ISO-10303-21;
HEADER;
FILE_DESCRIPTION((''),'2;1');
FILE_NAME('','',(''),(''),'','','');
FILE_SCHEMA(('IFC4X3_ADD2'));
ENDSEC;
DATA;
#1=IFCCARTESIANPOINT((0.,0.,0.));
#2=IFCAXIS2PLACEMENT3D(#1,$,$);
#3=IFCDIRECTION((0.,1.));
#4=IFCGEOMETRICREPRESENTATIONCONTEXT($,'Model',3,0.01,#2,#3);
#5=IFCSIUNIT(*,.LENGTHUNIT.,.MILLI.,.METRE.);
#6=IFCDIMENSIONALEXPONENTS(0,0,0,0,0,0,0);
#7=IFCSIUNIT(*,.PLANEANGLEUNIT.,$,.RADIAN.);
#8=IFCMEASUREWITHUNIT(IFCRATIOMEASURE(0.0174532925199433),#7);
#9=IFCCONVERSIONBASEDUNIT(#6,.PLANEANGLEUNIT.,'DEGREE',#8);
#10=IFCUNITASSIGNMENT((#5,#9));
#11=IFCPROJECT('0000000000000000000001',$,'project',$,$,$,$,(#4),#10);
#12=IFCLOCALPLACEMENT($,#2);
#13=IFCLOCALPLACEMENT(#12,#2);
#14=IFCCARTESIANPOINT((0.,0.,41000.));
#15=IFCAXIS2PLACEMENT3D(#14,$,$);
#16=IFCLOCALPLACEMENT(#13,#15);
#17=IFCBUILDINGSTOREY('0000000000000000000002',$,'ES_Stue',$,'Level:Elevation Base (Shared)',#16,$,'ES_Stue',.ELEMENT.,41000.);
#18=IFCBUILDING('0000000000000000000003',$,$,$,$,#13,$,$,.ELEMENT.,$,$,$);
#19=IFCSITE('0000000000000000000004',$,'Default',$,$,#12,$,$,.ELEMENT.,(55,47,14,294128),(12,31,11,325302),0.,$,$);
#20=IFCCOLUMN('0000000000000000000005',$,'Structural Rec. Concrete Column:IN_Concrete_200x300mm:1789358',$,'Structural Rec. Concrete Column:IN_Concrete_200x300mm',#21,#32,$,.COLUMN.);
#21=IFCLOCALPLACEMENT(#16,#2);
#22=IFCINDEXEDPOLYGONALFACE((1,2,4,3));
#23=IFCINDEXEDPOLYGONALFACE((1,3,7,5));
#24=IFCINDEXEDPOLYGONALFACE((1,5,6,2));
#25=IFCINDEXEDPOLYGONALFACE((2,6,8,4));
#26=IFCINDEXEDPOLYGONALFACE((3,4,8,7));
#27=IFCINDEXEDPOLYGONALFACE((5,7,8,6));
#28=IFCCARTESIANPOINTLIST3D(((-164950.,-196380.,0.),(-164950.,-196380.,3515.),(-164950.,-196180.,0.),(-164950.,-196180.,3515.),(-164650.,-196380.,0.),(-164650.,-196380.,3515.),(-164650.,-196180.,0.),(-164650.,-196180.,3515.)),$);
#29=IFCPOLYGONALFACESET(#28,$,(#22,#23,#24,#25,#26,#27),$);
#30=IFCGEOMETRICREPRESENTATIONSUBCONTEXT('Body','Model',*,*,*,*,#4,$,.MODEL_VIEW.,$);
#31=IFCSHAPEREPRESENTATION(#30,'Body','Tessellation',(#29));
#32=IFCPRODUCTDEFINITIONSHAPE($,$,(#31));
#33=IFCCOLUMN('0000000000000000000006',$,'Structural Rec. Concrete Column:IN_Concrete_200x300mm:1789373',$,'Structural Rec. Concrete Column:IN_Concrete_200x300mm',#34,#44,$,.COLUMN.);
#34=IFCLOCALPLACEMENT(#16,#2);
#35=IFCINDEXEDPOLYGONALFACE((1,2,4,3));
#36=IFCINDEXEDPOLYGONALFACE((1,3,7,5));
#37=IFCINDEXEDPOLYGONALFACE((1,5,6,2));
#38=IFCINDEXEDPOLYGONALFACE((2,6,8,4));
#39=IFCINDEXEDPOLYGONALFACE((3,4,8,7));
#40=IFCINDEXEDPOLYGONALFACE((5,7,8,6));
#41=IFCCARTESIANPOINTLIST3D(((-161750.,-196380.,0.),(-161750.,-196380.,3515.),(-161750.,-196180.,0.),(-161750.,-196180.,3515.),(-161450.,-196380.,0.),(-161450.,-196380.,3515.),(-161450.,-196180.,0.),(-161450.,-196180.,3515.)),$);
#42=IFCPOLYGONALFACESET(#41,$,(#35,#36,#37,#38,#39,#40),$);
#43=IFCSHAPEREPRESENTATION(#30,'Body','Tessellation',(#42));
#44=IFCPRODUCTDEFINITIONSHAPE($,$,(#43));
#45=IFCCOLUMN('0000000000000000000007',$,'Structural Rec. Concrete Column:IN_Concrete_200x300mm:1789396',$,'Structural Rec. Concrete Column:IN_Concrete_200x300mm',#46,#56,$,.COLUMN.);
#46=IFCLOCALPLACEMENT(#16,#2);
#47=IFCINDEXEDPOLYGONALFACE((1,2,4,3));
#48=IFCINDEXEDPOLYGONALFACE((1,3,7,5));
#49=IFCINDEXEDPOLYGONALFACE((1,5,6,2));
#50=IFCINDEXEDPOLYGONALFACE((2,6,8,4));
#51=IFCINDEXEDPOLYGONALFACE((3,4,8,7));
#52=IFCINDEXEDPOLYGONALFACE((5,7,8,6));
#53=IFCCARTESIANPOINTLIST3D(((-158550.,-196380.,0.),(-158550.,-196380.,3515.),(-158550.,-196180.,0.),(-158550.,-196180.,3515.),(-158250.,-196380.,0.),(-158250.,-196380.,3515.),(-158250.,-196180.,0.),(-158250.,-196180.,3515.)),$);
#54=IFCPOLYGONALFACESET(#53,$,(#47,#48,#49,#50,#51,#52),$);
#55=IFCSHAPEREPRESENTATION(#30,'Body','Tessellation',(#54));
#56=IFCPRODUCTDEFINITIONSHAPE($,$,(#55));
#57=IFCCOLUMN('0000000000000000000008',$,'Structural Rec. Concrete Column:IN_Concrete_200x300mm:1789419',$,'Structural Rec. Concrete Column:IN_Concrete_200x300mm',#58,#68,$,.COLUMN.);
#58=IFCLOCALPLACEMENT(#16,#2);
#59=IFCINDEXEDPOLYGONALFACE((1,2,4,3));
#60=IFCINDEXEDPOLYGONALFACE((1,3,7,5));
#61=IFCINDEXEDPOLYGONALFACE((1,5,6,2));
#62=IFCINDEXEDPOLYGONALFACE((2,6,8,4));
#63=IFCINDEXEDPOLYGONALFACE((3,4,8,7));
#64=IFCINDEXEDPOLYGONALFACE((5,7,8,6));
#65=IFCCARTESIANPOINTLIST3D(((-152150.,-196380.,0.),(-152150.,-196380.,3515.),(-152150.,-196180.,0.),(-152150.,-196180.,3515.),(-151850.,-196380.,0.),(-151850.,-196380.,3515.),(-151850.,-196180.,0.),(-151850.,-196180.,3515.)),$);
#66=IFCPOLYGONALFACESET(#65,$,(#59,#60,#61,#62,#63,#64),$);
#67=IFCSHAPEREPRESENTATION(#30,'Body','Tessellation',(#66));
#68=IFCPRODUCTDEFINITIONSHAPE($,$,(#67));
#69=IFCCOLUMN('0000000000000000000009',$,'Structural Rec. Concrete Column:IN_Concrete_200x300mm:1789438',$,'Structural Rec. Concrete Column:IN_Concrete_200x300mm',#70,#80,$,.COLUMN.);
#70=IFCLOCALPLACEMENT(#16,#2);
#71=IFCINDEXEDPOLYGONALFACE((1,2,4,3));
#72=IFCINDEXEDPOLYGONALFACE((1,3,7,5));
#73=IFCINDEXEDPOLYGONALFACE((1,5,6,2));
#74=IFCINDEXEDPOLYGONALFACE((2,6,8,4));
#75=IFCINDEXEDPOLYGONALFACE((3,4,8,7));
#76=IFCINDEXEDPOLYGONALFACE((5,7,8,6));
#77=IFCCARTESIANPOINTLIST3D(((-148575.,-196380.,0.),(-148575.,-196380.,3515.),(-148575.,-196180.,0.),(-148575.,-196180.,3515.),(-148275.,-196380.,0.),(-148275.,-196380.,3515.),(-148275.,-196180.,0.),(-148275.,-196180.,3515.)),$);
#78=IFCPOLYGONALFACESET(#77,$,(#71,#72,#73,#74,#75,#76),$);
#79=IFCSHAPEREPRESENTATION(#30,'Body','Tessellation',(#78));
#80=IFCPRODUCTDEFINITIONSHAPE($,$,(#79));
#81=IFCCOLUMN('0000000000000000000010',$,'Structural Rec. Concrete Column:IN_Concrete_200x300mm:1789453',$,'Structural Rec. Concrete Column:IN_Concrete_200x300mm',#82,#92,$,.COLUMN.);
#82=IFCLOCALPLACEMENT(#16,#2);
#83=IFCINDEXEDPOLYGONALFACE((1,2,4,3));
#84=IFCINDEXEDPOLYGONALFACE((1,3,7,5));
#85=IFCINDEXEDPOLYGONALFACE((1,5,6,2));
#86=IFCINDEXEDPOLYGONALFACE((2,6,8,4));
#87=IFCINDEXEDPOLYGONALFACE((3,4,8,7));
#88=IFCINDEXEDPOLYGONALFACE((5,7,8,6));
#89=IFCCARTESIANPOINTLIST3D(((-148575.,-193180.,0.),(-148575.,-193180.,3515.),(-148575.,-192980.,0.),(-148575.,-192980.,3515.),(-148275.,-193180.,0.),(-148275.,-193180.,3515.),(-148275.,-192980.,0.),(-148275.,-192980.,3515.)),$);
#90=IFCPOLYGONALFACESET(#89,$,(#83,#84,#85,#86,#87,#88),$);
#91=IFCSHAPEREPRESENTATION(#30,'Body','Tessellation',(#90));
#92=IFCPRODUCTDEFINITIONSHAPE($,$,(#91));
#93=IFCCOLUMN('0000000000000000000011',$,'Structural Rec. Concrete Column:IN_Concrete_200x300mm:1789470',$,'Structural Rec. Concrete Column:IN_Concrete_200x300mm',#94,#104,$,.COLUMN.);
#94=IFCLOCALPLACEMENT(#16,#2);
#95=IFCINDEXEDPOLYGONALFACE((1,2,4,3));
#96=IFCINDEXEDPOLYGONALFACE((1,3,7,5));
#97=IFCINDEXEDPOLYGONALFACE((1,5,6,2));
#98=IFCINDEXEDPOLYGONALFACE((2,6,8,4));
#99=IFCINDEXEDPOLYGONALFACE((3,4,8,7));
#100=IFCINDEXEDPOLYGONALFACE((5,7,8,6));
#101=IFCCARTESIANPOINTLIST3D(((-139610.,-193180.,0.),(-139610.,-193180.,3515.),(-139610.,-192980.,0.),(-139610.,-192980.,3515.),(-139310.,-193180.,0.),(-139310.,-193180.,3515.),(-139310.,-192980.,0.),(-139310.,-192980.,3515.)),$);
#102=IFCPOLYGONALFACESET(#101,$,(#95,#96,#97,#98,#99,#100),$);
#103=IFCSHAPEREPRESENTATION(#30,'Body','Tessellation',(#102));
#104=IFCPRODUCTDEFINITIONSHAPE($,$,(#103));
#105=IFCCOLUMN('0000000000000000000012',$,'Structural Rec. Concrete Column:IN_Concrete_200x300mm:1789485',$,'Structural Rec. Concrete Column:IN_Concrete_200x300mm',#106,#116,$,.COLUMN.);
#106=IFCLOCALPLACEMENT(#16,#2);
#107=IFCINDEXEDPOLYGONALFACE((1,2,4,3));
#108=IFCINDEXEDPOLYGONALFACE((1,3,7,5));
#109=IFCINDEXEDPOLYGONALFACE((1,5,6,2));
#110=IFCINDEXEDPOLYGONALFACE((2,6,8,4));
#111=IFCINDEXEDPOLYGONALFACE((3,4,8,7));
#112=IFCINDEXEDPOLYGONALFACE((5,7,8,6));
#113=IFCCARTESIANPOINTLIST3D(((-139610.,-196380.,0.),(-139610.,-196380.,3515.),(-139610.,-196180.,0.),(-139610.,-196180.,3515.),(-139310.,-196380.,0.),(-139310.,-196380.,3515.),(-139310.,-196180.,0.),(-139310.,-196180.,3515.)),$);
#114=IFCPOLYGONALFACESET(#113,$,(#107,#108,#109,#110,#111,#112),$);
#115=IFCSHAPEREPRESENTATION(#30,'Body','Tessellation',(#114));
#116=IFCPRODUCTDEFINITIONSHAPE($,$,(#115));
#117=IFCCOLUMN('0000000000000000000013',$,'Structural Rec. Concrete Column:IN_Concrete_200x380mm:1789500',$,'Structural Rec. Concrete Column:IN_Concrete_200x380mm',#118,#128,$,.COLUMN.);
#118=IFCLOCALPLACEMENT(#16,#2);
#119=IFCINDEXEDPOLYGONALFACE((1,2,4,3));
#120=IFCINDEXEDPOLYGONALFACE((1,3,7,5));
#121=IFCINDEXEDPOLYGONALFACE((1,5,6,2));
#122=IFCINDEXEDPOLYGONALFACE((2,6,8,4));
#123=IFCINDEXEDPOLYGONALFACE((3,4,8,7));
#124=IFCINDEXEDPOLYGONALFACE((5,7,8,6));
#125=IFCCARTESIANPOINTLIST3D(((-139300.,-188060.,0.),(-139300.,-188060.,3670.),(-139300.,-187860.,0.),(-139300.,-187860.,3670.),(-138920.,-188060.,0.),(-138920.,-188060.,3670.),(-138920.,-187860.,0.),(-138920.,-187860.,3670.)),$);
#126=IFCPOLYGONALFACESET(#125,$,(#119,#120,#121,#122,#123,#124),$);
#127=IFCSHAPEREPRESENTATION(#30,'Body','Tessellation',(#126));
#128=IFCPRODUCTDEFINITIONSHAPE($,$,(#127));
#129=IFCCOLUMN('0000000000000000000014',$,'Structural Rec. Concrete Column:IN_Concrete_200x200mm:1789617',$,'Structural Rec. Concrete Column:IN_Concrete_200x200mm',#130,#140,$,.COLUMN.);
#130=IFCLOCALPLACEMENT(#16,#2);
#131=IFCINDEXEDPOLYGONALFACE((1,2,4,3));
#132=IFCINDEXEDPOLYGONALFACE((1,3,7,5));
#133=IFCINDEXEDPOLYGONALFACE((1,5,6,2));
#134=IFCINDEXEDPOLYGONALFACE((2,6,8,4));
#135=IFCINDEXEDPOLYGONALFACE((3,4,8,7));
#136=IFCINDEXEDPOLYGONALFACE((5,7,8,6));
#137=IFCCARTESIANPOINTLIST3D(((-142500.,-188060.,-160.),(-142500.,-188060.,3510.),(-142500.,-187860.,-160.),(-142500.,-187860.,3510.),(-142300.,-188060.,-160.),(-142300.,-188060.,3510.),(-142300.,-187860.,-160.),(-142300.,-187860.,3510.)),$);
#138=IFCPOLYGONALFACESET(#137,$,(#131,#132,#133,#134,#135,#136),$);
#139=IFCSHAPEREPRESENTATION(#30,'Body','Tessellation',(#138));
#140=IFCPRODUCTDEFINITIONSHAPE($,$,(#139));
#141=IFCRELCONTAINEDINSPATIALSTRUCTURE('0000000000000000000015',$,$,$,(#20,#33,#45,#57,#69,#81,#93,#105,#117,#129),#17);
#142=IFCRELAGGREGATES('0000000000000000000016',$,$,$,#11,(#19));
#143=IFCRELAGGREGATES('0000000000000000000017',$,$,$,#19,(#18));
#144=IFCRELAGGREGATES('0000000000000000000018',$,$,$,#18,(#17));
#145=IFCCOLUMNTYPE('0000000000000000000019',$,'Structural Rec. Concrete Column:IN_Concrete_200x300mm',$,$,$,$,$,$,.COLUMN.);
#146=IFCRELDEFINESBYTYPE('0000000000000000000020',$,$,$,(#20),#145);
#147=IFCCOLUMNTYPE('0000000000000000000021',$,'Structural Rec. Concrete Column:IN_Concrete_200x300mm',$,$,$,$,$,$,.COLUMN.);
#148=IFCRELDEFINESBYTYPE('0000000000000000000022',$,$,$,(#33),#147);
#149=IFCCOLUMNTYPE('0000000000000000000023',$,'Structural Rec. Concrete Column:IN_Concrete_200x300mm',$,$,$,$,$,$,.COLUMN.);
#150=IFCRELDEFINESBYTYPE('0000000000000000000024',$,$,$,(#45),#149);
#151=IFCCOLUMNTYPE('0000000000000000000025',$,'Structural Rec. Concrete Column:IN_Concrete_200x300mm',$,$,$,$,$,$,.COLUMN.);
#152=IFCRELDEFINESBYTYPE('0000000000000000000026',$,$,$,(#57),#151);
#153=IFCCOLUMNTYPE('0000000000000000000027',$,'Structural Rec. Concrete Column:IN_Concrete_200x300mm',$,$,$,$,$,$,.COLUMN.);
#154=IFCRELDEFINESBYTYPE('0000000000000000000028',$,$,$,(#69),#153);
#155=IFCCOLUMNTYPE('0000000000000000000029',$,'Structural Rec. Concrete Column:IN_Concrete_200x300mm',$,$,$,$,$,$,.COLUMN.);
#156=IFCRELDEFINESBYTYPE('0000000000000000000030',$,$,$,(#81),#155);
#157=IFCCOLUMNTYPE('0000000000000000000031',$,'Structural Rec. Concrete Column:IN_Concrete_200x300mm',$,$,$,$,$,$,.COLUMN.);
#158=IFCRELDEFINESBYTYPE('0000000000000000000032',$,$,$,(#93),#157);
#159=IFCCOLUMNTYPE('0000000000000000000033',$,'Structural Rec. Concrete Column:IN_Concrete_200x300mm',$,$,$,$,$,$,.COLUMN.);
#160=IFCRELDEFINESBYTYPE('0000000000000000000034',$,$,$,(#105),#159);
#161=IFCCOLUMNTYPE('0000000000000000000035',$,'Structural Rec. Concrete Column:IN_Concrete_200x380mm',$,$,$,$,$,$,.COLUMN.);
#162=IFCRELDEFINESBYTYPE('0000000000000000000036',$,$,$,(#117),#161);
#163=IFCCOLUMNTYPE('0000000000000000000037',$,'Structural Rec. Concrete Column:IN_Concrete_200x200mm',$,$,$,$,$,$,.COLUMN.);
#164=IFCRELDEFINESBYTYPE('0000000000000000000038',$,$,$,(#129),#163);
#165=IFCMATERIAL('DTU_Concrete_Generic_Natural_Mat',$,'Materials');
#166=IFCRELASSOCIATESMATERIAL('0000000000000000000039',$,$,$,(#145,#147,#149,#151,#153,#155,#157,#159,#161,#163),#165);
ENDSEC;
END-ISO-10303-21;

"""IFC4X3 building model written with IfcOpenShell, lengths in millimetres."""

from ifc_helpers import new_model, entity, si_unit, converted_unit, direction, frame, origin, origin_2d_with_axis, place, context, subcontext, project, spatial, rectangle, extrude, source, transform, mapped, material, material_profile, profile_set, type_object, type_shapes, element, save


model = new_model("IFC4X3")

# Units and contexts
model_context = context("Model", 3, precision=0.01, world=origin(), true_north=direction((0.0, 1.0)))
body_context = subcontext(model_context, "Body", "Model", "MODEL_VIEW")
ifc_project = project(units=[si_unit("LENGTHUNIT", "METRE", prefix="MILLI"), converted_unit("PLANEANGLEUNIT", "DEGREE", entity("IfcRatioMeasure", 0.0174532925199433), si_unit("PLANEANGLEUNIT", "RADIAN"), dimensions=[0, 0, 0, 0, 0, 0, 0])], contexts=[model_context])

# Site, building, storey
site_placement = place(None, origin())
site = spatial("IfcSite", under=ifc_project, at=site_placement, Name="Default", CompositionType="ELEMENT", RefLatitude=(55, 47, 14, 294128), RefLongitude=(12, 31, 11, 325302), RefElevation=0.0)
building_placement = place(site_placement, origin())
building = spatial("IfcBuilding", under=site, at=building_placement, CompositionType="ELEMENT")
storey_placement = place(building_placement, frame((0.0, 0.0, 41000.0)))
storey = spatial("IfcBuildingStorey", under=building, at=storey_placement, Name="ES_Stue", ObjectType="Level:Elevation Base (Shared)", LongName="ES_Stue", CompositionType="ELEMENT", Elevation=41000.0)

# Columns
ifc_material = material(Name="DTU_Concrete_Generic_Natural_Mat", Category="Materials")
ifc_material_profile_1 = material_profile(ifc_material, rectangle(XDim=200.0, YDim=300.0, at=origin_2d_with_axis()), Name="IN_Concrete_200x300mm")
ifc_profile_set_1 = profile_set([ifc_material_profile_1], Name="IN_Concrete_200x300mm")
column_type_1 = type_object("IfcColumnType", Name="Structural Rec. Concrete Column:IN_Concrete_200x300mm", PredefinedType="COLUMN", material=ifc_profile_set_1)
shared_shape_1 = source(origin(), body_context, "Body", "SweptSolid", [
    extrude(rectangle(XDim=200.0, YDim=300.0, at=origin_2d_with_axis()), frame((-164800.0, -196280.0, 41000.0), z_axis=(0.0, 0.0, 1.0), x_axis=(0.0, -1.0, 0.0)), (0.0, 0.0, 1.0), 3515.0),
])
type_shapes(column_type_1, [shared_shape_1])
column_1_placement = place(storey_placement, frame((0.0, 0.0, -41000.0)))
element("IfcColumn", 1, at=column_1_placement, inside=storey, type_object=column_type_1, Name="Structural Rec. Concrete Column:IN_Concrete_200x300mm:1789358", ObjectType="Structural Rec. Concrete Column:IN_Concrete_200x300mm", PredefinedType="COLUMN", context=body_context, shape_type="MappedRepresentation", body=[
    mapped(shared_shape_1, transform((0.0, 0.0, 0.0), scale=1.0)),
])
column_type_2 = type_object("IfcColumnType", Name="Structural Rec. Concrete Column:IN_Concrete_200x300mm", PredefinedType="COLUMN", material=ifc_profile_set_1)
shared_shape_2 = source(origin(), body_context, "Body", "SweptSolid", [
    extrude(rectangle(XDim=200.0, YDim=300.0, at=origin_2d_with_axis()), frame((-161600.0, -196280.0, 41000.0), z_axis=(0.0, 0.0, 1.0), x_axis=(0.0, -1.0, 0.0)), (0.0, 0.0, 1.0), 3515.0),
])
type_shapes(column_type_2, [shared_shape_2])
column_2_placement = place(storey_placement, frame((0.0, 0.0, -41000.0)))
element("IfcColumn", 2, at=column_2_placement, inside=storey, type_object=column_type_2, Name="Structural Rec. Concrete Column:IN_Concrete_200x300mm:1789373", ObjectType="Structural Rec. Concrete Column:IN_Concrete_200x300mm", PredefinedType="COLUMN", context=body_context, shape_type="MappedRepresentation", body=[
    mapped(shared_shape_2, transform((0.0, 0.0, 0.0), scale=1.0)),
])
column_type_3 = type_object("IfcColumnType", Name="Structural Rec. Concrete Column:IN_Concrete_200x300mm", PredefinedType="COLUMN", material=ifc_profile_set_1)
shared_shape_3 = source(origin(), body_context, "Body", "SweptSolid", [
    extrude(rectangle(XDim=200.0, YDim=300.0, at=origin_2d_with_axis()), frame((-158400.0, -196280.0, 41000.0), z_axis=(0.0, 0.0, 1.0), x_axis=(0.0, -1.0, 0.0)), (0.0, 0.0, 1.0), 3515.0),
])
type_shapes(column_type_3, [shared_shape_3])
column_3_placement = place(storey_placement, frame((0.0, 0.0, -41000.0)))
element("IfcColumn", 3, at=column_3_placement, inside=storey, type_object=column_type_3, Name="Structural Rec. Concrete Column:IN_Concrete_200x300mm:1789396", ObjectType="Structural Rec. Concrete Column:IN_Concrete_200x300mm", PredefinedType="COLUMN", context=body_context, shape_type="MappedRepresentation", body=[
    mapped(shared_shape_3, transform((0.0, 0.0, 0.0), scale=1.0)),
])
column_type_4 = type_object("IfcColumnType", Name="Structural Rec. Concrete Column:IN_Concrete_200x300mm", PredefinedType="COLUMN", material=ifc_profile_set_1)
shared_shape_4 = source(origin(), body_context, "Body", "SweptSolid", [
    extrude(rectangle(XDim=200.0, YDim=300.0, at=origin_2d_with_axis()), frame((-152000.0, -196280.0, 41000.0), z_axis=(0.0, 0.0, 1.0), x_axis=(0.0, -1.0, 0.0)), (0.0, 0.0, 1.0), 3515.0),
])
type_shapes(column_type_4, [shared_shape_4])
column_4_placement = place(storey_placement, frame((0.0, 0.0, -41000.0)))
element("IfcColumn", 4, at=column_4_placement, inside=storey, type_object=column_type_4, Name="Structural Rec. Concrete Column:IN_Concrete_200x300mm:1789419", ObjectType="Structural Rec. Concrete Column:IN_Concrete_200x300mm", PredefinedType="COLUMN", context=body_context, shape_type="MappedRepresentation", body=[
    mapped(shared_shape_4, transform((0.0, 0.0, 0.0), scale=1.0)),
])
column_type_5 = type_object("IfcColumnType", Name="Structural Rec. Concrete Column:IN_Concrete_200x300mm", PredefinedType="COLUMN", material=ifc_profile_set_1)
shared_shape_5 = source(origin(), body_context, "Body", "SweptSolid", [
    extrude(rectangle(XDim=200.0, YDim=300.0, at=origin_2d_with_axis()), frame((-148425.0, -196280.0, 41000.0), z_axis=(0.0, 0.0, 1.0), x_axis=(0.0, -1.0, 0.0)), (0.0, 0.0, 1.0), 3515.0),
])
type_shapes(column_type_5, [shared_shape_5])
column_5_placement = place(storey_placement, frame((0.0, 0.0, -41000.0)))
element("IfcColumn", 5, at=column_5_placement, inside=storey, type_object=column_type_5, Name="Structural Rec. Concrete Column:IN_Concrete_200x300mm:1789438", ObjectType="Structural Rec. Concrete Column:IN_Concrete_200x300mm", PredefinedType="COLUMN", context=body_context, shape_type="MappedRepresentation", body=[
    mapped(shared_shape_5, transform((0.0, 0.0, 0.0), scale=1.0)),
])
column_type_6 = type_object("IfcColumnType", Name="Structural Rec. Concrete Column:IN_Concrete_200x300mm", PredefinedType="COLUMN", material=ifc_profile_set_1)
shared_shape_6 = source(origin(), body_context, "Body", "SweptSolid", [
    extrude(rectangle(XDim=200.0, YDim=300.0, at=origin_2d_with_axis()), frame((-148425.0, -193080.0, 41000.0), z_axis=(0.0, 0.0, 1.0), x_axis=(0.0, -1.0, 0.0)), (0.0, 0.0, 1.0), 3515.0),
])
type_shapes(column_type_6, [shared_shape_6])
column_6_placement = place(storey_placement, frame((0.0, 0.0, -41000.0)))
element("IfcColumn", 6, at=column_6_placement, inside=storey, type_object=column_type_6, Name="Structural Rec. Concrete Column:IN_Concrete_200x300mm:1789453", ObjectType="Structural Rec. Concrete Column:IN_Concrete_200x300mm", PredefinedType="COLUMN", context=body_context, shape_type="MappedRepresentation", body=[
    mapped(shared_shape_6, transform((0.0, 0.0, 0.0), scale=1.0)),
])
column_type_7 = type_object("IfcColumnType", Name="Structural Rec. Concrete Column:IN_Concrete_200x300mm", PredefinedType="COLUMN", material=ifc_profile_set_1)
shared_shape_7 = source(origin(), body_context, "Body", "SweptSolid", [
    extrude(rectangle(XDim=200.0, YDim=300.0, at=origin_2d_with_axis()), frame((-139460.0, -193080.0, 41000.0), z_axis=(0.0, 0.0, 1.0), x_axis=(0.0, -1.0, 0.0)), (0.0, 0.0, 1.0), 3515.0),
])
type_shapes(column_type_7, [shared_shape_7])
column_7_placement = place(storey_placement, frame((0.0, 0.0, -41000.0)))
element("IfcColumn", 7, at=column_7_placement, inside=storey, type_object=column_type_7, Name="Structural Rec. Concrete Column:IN_Concrete_200x300mm:1789470", ObjectType="Structural Rec. Concrete Column:IN_Concrete_200x300mm", PredefinedType="COLUMN", context=body_context, shape_type="MappedRepresentation", body=[
    mapped(shared_shape_7, transform((0.0, 0.0, 0.0), scale=1.0)),
])
column_type_8 = type_object("IfcColumnType", Name="Structural Rec. Concrete Column:IN_Concrete_200x300mm", PredefinedType="COLUMN", material=ifc_profile_set_1)
shared_shape_8 = source(origin(), body_context, "Body", "SweptSolid", [
    extrude(rectangle(XDim=200.0, YDim=300.0, at=origin_2d_with_axis()), frame((-139460.0, -196280.0, 41000.0), z_axis=(0.0, 0.0, 1.0), x_axis=(0.0, -1.0, 0.0)), (0.0, 0.0, 1.0), 3515.0),
])
type_shapes(column_type_8, [shared_shape_8])
column_8_placement = place(storey_placement, frame((0.0, 0.0, -41000.0)))
element("IfcColumn", 8, at=column_8_placement, inside=storey, type_object=column_type_8, Name="Structural Rec. Concrete Column:IN_Concrete_200x300mm:1789485", ObjectType="Structural Rec. Concrete Column:IN_Concrete_200x300mm", PredefinedType="COLUMN", context=body_context, shape_type="MappedRepresentation", body=[
    mapped(shared_shape_8, transform((0.0, 0.0, 0.0), scale=1.0)),
])
ifc_material_profile_2 = material_profile(ifc_material, rectangle(XDim=200.0, YDim=380.0, at=origin_2d_with_axis()), Name="IN_Concrete_200x380mm")
ifc_profile_set_2 = profile_set([ifc_material_profile_2], Name="IN_Concrete_200x380mm")
column_type_9 = type_object("IfcColumnType", Name="Structural Rec. Concrete Column:IN_Concrete_200x380mm", PredefinedType="COLUMN", material=ifc_profile_set_2)
shared_shape_9 = source(origin(), body_context, "Body", "SweptSolid", [
    extrude(rectangle(XDim=200.0, YDim=380.0, at=origin_2d_with_axis()), frame((-139110.0, -187960.0, 41000.0), z_axis=(0.0, 0.0, 1.0), x_axis=(0.0, -1.0, 0.0)), (0.0, 0.0, 1.0), 3670.0),
])
type_shapes(column_type_9, [shared_shape_9])
column_9_placement = place(storey_placement, frame((0.0, 0.0, -41000.0)))
element("IfcColumn", 9, at=column_9_placement, inside=storey, type_object=column_type_9, Name="Structural Rec. Concrete Column:IN_Concrete_200x380mm:1789500", ObjectType="Structural Rec. Concrete Column:IN_Concrete_200x380mm", PredefinedType="COLUMN", context=body_context, shape_type="MappedRepresentation", body=[
    mapped(shared_shape_9, transform((0.0, 0.0, 0.0), scale=1.0)),
])
ifc_material_profile_3 = material_profile(ifc_material, rectangle(XDim=200.0, YDim=200.0, at=origin_2d_with_axis()), Name="IN_Concrete_200x200mm")
ifc_profile_set_3 = profile_set([ifc_material_profile_3], Name="IN_Concrete_200x200mm")
column_type_10 = type_object("IfcColumnType", Name="Structural Rec. Concrete Column:IN_Concrete_200x200mm", PredefinedType="COLUMN", material=ifc_profile_set_3)
shared_shape_10 = source(origin(), body_context, "Body", "SweptSolid", [
    extrude(rectangle(XDim=200.0, YDim=200.0, at=origin_2d_with_axis()), frame((-142400.0, -187960.0, 40840.0), z_axis=(0.0, 0.0, 1.0), x_axis=(0.0, -1.0, 0.0)), (0.0, 0.0, 1.0), 3670.0),
])
type_shapes(column_type_10, [shared_shape_10])
column_10_placement = place(storey_placement, frame((0.0, 0.0, -41000.0)))
element("IfcColumn", 10, at=column_10_placement, inside=storey, type_object=column_type_10, Name="Structural Rec. Concrete Column:IN_Concrete_200x200mm:1789617", ObjectType="Structural Rec. Concrete Column:IN_Concrete_200x200mm", PredefinedType="COLUMN", context=body_context, shape_type="MappedRepresentation", body=[
    mapped(shared_shape_10, transform((0.0, 0.0, 0.0), scale=1.0)),
])

save(model, "model.ifc")
